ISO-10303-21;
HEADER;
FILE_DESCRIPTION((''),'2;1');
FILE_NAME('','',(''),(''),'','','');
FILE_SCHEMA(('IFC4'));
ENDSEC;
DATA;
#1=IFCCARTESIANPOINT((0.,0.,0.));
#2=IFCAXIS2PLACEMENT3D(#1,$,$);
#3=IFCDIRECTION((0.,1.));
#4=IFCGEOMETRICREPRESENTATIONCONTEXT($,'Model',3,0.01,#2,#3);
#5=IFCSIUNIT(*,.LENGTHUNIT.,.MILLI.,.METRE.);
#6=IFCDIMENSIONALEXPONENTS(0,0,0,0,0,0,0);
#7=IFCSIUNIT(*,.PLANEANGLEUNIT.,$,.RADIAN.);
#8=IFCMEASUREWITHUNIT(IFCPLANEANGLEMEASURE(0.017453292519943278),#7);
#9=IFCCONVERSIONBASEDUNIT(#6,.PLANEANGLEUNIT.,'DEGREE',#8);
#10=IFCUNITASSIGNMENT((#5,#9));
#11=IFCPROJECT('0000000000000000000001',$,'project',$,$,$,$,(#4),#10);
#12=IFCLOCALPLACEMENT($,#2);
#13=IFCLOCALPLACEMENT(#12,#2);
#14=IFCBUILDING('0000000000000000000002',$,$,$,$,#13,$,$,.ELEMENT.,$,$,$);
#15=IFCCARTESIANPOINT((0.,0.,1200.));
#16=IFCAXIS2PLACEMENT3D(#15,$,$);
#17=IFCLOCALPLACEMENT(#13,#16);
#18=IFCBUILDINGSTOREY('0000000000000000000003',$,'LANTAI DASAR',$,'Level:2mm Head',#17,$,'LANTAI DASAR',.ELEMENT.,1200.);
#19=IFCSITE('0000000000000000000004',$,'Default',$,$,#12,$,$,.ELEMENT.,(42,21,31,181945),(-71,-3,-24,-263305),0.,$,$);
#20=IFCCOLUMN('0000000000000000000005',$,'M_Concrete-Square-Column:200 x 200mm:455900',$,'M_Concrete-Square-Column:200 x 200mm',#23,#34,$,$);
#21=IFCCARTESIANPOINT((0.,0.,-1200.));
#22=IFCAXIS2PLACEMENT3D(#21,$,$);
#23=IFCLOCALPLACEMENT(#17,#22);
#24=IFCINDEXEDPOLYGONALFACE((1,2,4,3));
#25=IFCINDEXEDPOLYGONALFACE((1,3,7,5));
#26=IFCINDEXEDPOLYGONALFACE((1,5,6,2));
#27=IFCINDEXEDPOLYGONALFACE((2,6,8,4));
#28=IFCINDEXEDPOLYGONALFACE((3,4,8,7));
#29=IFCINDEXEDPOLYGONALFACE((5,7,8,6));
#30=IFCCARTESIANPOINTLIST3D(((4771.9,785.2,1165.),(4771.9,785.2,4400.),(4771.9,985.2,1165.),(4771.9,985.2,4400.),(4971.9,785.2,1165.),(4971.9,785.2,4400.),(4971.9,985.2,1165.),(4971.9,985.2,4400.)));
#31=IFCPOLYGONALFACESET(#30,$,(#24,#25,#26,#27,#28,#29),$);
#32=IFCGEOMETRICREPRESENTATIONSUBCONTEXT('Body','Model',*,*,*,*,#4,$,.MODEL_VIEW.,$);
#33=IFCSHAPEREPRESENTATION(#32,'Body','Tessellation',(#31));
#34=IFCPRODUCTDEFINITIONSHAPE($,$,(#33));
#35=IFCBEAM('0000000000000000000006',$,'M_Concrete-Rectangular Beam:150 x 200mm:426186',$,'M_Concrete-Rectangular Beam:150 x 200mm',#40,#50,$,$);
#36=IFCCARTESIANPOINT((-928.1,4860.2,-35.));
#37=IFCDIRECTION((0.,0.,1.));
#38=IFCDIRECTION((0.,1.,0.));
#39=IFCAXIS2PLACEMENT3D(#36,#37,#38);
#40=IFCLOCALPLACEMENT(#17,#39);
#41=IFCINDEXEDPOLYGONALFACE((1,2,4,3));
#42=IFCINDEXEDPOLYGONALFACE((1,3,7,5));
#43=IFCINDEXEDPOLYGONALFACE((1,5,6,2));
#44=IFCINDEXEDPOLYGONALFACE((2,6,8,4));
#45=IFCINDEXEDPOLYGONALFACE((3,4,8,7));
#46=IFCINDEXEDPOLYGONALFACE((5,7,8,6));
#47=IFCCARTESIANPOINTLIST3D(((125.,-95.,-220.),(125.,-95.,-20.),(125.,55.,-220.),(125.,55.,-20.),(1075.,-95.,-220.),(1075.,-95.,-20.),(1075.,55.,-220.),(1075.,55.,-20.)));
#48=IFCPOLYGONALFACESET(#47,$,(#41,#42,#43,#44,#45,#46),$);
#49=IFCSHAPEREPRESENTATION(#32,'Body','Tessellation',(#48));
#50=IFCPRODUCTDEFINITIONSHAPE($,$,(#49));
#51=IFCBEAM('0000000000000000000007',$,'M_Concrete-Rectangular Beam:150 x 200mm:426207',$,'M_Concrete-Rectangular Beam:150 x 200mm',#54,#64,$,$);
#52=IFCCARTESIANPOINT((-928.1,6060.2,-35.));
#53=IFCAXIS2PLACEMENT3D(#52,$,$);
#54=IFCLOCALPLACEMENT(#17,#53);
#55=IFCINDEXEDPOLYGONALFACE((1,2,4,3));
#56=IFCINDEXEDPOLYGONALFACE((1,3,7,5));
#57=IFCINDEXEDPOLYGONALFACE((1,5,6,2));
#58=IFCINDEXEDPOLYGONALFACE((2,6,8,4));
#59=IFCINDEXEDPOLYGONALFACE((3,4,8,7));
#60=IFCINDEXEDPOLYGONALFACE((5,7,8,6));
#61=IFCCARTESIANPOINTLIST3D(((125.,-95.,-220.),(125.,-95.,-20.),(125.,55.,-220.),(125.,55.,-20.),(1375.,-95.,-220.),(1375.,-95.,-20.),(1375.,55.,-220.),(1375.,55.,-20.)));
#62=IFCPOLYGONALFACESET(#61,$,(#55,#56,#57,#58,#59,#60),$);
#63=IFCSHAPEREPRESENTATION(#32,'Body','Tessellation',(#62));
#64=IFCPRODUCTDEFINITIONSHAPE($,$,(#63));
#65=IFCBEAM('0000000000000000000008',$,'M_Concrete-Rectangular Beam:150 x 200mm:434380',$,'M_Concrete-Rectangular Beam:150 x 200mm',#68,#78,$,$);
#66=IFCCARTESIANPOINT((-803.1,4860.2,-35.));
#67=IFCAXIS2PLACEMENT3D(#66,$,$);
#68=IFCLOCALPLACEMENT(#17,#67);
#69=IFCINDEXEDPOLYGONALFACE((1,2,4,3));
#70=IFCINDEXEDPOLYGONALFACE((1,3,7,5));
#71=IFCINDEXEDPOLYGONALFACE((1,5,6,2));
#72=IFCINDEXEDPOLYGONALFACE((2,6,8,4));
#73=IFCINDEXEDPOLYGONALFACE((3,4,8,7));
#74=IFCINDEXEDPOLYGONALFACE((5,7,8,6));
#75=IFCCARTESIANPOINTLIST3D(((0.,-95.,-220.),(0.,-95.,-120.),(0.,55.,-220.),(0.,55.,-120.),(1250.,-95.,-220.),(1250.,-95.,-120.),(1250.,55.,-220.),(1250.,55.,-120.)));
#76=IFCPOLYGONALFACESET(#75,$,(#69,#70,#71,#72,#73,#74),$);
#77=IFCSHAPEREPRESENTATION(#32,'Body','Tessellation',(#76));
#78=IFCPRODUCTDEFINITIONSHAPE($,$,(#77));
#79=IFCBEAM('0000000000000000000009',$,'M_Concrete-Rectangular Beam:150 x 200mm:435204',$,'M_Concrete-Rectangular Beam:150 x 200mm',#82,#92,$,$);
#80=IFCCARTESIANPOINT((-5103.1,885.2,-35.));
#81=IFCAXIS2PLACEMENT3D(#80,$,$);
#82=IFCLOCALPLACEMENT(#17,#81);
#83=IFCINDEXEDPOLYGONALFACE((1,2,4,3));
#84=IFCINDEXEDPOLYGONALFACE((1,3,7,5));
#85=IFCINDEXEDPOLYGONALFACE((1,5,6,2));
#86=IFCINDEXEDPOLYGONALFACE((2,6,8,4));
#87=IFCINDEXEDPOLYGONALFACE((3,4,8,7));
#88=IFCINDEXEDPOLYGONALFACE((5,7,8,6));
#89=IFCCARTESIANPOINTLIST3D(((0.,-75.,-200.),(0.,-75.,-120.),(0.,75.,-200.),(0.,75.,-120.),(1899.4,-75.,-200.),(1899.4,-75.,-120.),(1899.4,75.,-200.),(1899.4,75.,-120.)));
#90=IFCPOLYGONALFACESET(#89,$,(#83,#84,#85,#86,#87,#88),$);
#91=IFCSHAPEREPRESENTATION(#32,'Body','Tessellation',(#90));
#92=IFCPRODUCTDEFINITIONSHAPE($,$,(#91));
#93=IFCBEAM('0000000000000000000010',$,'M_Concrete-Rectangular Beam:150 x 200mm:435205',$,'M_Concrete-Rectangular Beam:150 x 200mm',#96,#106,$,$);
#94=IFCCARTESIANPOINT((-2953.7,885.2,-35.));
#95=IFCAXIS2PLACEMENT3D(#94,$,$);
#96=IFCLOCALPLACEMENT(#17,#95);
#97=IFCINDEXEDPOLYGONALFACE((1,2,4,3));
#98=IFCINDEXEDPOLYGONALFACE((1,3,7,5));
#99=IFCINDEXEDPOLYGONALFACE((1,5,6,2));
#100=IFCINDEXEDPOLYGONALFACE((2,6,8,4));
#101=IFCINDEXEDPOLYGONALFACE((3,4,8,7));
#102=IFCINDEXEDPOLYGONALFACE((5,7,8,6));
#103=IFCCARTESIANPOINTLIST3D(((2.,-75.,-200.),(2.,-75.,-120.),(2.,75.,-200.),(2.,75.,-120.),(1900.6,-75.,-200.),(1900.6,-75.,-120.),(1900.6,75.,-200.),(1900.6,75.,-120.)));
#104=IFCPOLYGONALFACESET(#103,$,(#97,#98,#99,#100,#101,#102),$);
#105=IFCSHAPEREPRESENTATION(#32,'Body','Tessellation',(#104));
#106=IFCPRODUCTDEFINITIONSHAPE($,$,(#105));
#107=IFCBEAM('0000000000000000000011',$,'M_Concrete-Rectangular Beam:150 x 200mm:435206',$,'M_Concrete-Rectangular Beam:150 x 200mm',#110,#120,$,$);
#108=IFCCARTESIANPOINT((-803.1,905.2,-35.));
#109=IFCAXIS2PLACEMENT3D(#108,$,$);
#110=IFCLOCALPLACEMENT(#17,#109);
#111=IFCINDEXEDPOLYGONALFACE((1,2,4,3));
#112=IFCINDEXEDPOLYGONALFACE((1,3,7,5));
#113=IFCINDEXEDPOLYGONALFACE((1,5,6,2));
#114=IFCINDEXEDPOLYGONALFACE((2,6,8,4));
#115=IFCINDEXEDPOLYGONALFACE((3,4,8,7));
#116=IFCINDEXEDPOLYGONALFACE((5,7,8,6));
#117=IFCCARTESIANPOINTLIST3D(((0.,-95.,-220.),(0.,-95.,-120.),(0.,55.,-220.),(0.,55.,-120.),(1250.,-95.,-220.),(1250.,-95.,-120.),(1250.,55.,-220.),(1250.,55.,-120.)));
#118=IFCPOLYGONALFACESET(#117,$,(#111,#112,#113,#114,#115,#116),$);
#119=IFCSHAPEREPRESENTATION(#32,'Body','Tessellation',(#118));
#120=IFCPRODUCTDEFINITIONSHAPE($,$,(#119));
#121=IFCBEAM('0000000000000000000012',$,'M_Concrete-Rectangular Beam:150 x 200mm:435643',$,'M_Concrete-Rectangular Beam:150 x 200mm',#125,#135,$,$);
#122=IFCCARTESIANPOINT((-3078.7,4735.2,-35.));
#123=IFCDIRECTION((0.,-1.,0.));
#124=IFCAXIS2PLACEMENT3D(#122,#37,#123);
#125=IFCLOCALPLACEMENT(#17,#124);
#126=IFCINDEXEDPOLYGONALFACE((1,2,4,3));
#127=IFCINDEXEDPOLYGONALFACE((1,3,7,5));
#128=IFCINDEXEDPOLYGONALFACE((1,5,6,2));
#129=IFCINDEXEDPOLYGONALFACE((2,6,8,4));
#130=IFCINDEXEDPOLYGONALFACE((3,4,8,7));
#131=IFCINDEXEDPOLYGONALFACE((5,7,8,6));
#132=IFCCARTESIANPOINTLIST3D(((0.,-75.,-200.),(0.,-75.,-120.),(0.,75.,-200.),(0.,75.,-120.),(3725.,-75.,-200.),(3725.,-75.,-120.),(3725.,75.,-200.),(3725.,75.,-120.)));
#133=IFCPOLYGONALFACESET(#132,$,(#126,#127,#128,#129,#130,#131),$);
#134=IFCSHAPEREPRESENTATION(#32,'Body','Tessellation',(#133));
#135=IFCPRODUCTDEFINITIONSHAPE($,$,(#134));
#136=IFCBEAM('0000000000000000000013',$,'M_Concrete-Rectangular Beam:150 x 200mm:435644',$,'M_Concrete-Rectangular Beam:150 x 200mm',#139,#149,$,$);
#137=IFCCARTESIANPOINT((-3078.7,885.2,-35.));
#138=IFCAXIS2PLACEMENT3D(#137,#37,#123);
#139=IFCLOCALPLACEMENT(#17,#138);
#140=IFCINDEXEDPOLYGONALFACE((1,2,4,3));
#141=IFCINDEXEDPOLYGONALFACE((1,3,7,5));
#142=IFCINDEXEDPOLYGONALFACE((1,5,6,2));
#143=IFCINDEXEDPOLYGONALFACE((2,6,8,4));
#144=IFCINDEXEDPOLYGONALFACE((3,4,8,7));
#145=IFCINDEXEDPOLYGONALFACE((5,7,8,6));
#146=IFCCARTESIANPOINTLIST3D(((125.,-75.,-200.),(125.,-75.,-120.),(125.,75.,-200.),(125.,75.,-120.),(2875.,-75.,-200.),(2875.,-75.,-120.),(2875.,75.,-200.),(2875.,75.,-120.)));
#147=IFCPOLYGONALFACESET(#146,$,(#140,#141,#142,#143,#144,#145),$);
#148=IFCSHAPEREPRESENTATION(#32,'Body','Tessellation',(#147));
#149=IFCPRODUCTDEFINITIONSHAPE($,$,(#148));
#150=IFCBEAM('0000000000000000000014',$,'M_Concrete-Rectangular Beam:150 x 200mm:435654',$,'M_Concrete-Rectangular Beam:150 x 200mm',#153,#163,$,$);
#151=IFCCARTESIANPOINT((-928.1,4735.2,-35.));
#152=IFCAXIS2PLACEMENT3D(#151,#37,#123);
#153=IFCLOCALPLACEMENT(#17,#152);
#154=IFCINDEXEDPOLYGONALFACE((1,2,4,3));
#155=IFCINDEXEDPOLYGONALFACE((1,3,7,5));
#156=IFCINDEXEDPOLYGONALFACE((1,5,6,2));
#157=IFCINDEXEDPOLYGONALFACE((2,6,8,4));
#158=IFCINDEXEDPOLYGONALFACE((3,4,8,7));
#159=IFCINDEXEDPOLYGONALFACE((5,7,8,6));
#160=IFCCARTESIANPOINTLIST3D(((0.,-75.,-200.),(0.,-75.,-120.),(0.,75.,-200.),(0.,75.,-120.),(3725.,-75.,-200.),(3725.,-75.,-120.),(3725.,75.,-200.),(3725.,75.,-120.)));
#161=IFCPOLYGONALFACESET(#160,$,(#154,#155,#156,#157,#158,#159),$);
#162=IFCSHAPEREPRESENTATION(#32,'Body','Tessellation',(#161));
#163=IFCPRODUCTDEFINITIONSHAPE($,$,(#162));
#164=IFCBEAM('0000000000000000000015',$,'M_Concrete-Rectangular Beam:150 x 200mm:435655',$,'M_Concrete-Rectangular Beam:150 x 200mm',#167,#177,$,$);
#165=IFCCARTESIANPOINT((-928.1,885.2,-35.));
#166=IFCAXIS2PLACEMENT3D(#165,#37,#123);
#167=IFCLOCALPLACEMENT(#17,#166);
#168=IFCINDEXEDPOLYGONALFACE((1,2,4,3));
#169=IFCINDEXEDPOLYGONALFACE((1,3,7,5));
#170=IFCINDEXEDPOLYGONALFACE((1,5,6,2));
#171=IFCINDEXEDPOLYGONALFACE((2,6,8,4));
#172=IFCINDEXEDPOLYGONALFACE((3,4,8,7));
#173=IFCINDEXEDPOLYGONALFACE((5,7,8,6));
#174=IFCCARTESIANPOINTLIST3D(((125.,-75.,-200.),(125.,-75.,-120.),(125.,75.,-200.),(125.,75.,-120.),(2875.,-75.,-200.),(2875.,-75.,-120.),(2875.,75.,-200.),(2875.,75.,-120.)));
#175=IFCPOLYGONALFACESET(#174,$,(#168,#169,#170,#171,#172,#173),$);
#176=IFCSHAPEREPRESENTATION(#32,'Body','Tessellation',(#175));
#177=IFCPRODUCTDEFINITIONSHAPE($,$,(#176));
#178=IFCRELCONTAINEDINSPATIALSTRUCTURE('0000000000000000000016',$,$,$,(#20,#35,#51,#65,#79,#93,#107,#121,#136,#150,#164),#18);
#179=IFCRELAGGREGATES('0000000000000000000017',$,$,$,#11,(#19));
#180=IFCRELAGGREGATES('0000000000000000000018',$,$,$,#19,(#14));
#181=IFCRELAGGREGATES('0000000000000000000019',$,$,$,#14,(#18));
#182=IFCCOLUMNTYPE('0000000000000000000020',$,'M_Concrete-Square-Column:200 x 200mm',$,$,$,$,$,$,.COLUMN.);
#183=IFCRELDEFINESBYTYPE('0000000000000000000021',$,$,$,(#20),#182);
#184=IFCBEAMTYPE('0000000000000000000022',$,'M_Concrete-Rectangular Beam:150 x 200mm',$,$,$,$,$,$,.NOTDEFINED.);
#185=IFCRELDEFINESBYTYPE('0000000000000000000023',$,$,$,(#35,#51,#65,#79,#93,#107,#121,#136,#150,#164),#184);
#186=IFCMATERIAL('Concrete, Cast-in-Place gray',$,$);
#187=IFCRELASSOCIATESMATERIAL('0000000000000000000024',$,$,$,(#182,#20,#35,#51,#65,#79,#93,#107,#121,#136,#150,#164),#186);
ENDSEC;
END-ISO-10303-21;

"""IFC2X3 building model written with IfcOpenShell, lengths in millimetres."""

from ifc_helpers import new_model, entity, si_unit, converted_unit, direction, frame, frame_2d, origin, origin_2d_with_axis, place, context, subcontext, project, spatial, rectangle, extrude, source, transform, mapped, material, type_object, type_shapes, element, save


model = new_model("IFC2X3")

# Units and contexts
model_context = context("Model", 3, precision=0.01, world=origin(), true_north=direction((0.0, 1.0)))
body_context = subcontext(model_context, "Body", "Model", "MODEL_VIEW")
ifc_project = project(units=[si_unit("LENGTHUNIT", "METRE", prefix="MILLI"), converted_unit("PLANEANGLEUNIT", "DEGREE", entity("IfcPlaneAngleMeasure", 0.017453292519943278), si_unit("PLANEANGLEUNIT", "RADIAN"), dimensions=[0, 0, 0, 0, 0, 0, 0])], contexts=[model_context])

# Site, building, storey
site_placement = place(None, origin())
site = spatial("IfcSite", under=ifc_project, at=site_placement, Name="Default", CompositionType="ELEMENT", RefLatitude=(42, 21, 31, 181945), RefLongitude=(-71, -3, -24, -263305), RefElevation=0.0)
building_placement = place(site_placement, origin())
building = spatial("IfcBuilding", under=site, at=building_placement, CompositionType="ELEMENT")
storey_placement = place(building_placement, frame((0.0, 0.0, 1200.0)))
storey = spatial("IfcBuildingStorey", under=building, at=storey_placement, Name="LANTAI DASAR", ObjectType="Level:2mm Head", LongName="LANTAI DASAR", CompositionType="ELEMENT", Elevation=1200.0)

# Column
ifc_material_1 = material(Name="Concrete, Cast-in-Place gray")
column_type = type_object("IfcColumnType", Name="M_Concrete-Square-Column:200 x 200mm", PredefinedType="COLUMN", material=ifc_material_1)
shared_shape = source(origin(), body_context, "Body", "SweptSolid", [
    extrude(rectangle(XDim=200.0, YDim=200.0, at=origin_2d_with_axis()), frame((4871.9, 885.2, 1165.0), z_axis=(0.0, 0.0, 1.0), x_axis=(-1.0, 0.0, 0.0)), (0.0, 0.0, 1.0), 3235.0),
])
type_shapes(column_type, [shared_shape])
column_placement = place(storey_placement, frame((0.0, 0.0, -1200.0)))
element("IfcColumn", 1, at=column_placement, inside=storey, type_object=column_type, material=ifc_material_1, Name="M_Concrete-Square-Column:200 x 200mm:455900", ObjectType="M_Concrete-Square-Column:200 x 200mm", context=body_context, shape_type="MappedRepresentation", body=[
    mapped(shared_shape, transform((0.0, 0.0, 0.0), scale=1.0)),
])

# Beams
beam_type = type_object("IfcBeamType", Name="M_Concrete-Rectangular Beam:150 x 200mm", PredefinedType="NOTDEFINED")
beam_1_placement = place(storey_placement, frame((-928.1, 4860.2, -35.0), z_axis=(0.0, 0.0, 1.0), x_axis=(0.0, 1.0, 0.0)))
element("IfcBeam", 2, at=beam_1_placement, inside=storey, type_object=beam_type, material=ifc_material_1, Name="M_Concrete-Rectangular Beam:150 x 200mm:426186", ObjectType="M_Concrete-Rectangular Beam:150 x 200mm", context=body_context, shape_type="SweptSolid", body=[
    extrude(rectangle(XDim=200.0, YDim=150.0, at=frame_2d((0.0, 0.0), x_axis=(1.0, 0.0))), frame((125.0, -20.0, -120.0), z_axis=(1.0, 0.0, 0.0), x_axis=(0.0, 0.0, -1.0)), (0.0, 0.0, 1.0), 950.0),
])
beam_2_placement = place(storey_placement, frame((-928.1, 6060.2, -35.0)))
element("IfcBeam", 3, at=beam_2_placement, inside=storey, type_object=beam_type, material=ifc_material_1, Name="M_Concrete-Rectangular Beam:150 x 200mm:426207", ObjectType="M_Concrete-Rectangular Beam:150 x 200mm", context=body_context, shape_type="SweptSolid", body=[
    extrude(rectangle(XDim=200.0, YDim=150.0, at=frame_2d((0.0, 0.0), x_axis=(1.0, 0.0))), frame((125.0, -20.0, -120.0), z_axis=(1.0, 0.0, 0.0), x_axis=(0.0, 0.0, -1.0)), (0.0, 0.0, 1.0), 1250.0),
])
beam_3_placement = place(storey_placement, frame((-803.1, 4860.2, -35.0)))
element("IfcBeam", 4, at=beam_3_placement, inside=storey, type_object=beam_type, material=ifc_material_1, Name="M_Concrete-Rectangular Beam:150 x 200mm:434380", ObjectType="M_Concrete-Rectangular Beam:150 x 200mm", context=body_context, shape_type="SweptSolid", body=[
    extrude(rectangle(XDim=100.0, YDim=150.0, at=frame_2d((0.0, 0.0), x_axis=(1.0, 0.0))), frame((0.0, -20.0, -170.0), z_axis=(1.0, 0.0, 0.0), x_axis=(0.0, 0.0, -1.0)), (0.0, 0.0, 1.0), 1250.0),
])
beam_4_placement = place(storey_placement, frame((-5103.1, 885.2, -35.0)))
element("IfcBeam", 5, at=beam_4_placement, inside=storey, type_object=beam_type, material=ifc_material_1, Name="M_Concrete-Rectangular Beam:150 x 200mm:435204", ObjectType="M_Concrete-Rectangular Beam:150 x 200mm", context=body_context, shape_type="SweptSolid", body=[
    extrude(rectangle(XDim=80.0, YDim=150.0, at=frame_2d((0.0, 0.0), x_axis=(1.0, 0.0))), frame((0.0, 0.0, -160.0), z_axis=(1.0, 0.0, 0.0), x_axis=(0.0, 0.0, -1.0)), (0.0, 0.0, 1.0), 1899.4),
])
beam_5_placement = place(storey_placement, frame((-2953.7, 885.2, -35.0)))
element("IfcBeam", 6, at=beam_5_placement, inside=storey, type_object=beam_type, material=ifc_material_1, Name="M_Concrete-Rectangular Beam:150 x 200mm:435205", ObjectType="M_Concrete-Rectangular Beam:150 x 200mm", context=body_context, shape_type="SweptSolid", body=[
    extrude(rectangle(XDim=80.0, YDim=150.0, at=frame_2d((0.0, 0.0), x_axis=(1.0, 0.0))), frame((2.0, 0.0, -160.0), z_axis=(1.0, 0.0, 0.0), x_axis=(0.0, 0.0, -1.0)), (0.0, 0.0, 1.0), 1898.6),
])
beam_6_placement = place(storey_placement, frame((-803.1, 905.2, -35.0)))
element("IfcBeam", 7, at=beam_6_placement, inside=storey, type_object=beam_type, material=ifc_material_1, Name="M_Concrete-Rectangular Beam:150 x 200mm:435206", ObjectType="M_Concrete-Rectangular Beam:150 x 200mm", context=body_context, shape_type="SweptSolid", body=[
    extrude(rectangle(XDim=100.0, YDim=150.0, at=frame_2d((0.0, 0.0), x_axis=(1.0, 0.0))), frame((0.0, -20.0, -170.0), z_axis=(1.0, 0.0, 0.0), x_axis=(0.0, 0.0, -1.0)), (0.0, 0.0, 1.0), 1250.0),
])
beam_7_placement = place(storey_placement, frame((-3078.7, 4735.2, -35.0), z_axis=(0.0, 0.0, 1.0), x_axis=(0.0, -1.0, 0.0)))
element("IfcBeam", 8, at=beam_7_placement, inside=storey, type_object=beam_type, material=ifc_material_1, Name="M_Concrete-Rectangular Beam:150 x 200mm:435643", ObjectType="M_Concrete-Rectangular Beam:150 x 200mm", context=body_context, shape_type="SweptSolid", body=[
    extrude(rectangle(XDim=80.0, YDim=150.0, at=frame_2d((0.0, 0.0), x_axis=(1.0, 0.0))), frame((0.0, 0.0, -160.0), z_axis=(1.0, 0.0, 0.0), x_axis=(0.0, 0.0, -1.0)), (0.0, 0.0, 1.0), 3725.0),
])
beam_8_placement = place(storey_placement, frame((-3078.7, 885.2, -35.0), z_axis=(0.0, 0.0, 1.0), x_axis=(0.0, -1.0, 0.0)))
element("IfcBeam", 9, at=beam_8_placement, inside=storey, type_object=beam_type, material=ifc_material_1, Name="M_Concrete-Rectangular Beam:150 x 200mm:435644", ObjectType="M_Concrete-Rectangular Beam:150 x 200mm", context=body_context, shape_type="SweptSolid", body=[
    extrude(rectangle(XDim=80.0, YDim=150.0, at=frame_2d((0.0, 0.0), x_axis=(1.0, 0.0))), frame((125.0, 0.0, -160.0), z_axis=(1.0, 0.0, 0.0), x_axis=(0.0, 0.0, -1.0)), (0.0, 0.0, 1.0), 2750.0),
])
beam_9_placement = place(storey_placement, frame((-928.1, 4735.2, -35.0), z_axis=(0.0, 0.0, 1.0), x_axis=(0.0, -1.0, 0.0)))
element("IfcBeam", 10, at=beam_9_placement, inside=storey, type_object=beam_type, material=ifc_material_1, Name="M_Concrete-Rectangular Beam:150 x 200mm:435654", ObjectType="M_Concrete-Rectangular Beam:150 x 200mm", context=body_context, shape_type="SweptSolid", body=[
    extrude(rectangle(XDim=80.0, YDim=150.0, at=frame_2d((0.0, 0.0), x_axis=(1.0, 0.0))), frame((0.0, 0.0, -160.0), z_axis=(1.0, 0.0, 0.0), x_axis=(0.0, 0.0, -1.0)), (0.0, 0.0, 1.0), 3725.0),
])
beam_10_placement = place(storey_placement, frame((-928.1, 885.2, -35.0), z_axis=(0.0, 0.0, 1.0), x_axis=(0.0, -1.0, 0.0)))
element("IfcBeam", 11, at=beam_10_placement, inside=storey, type_object=beam_type, material=ifc_material_1, Name="M_Concrete-Rectangular Beam:150 x 200mm:435655", ObjectType="M_Concrete-Rectangular Beam:150 x 200mm", context=body_context, shape_type="SweptSolid", body=[
    extrude(rectangle(XDim=80.0, YDim=150.0, at=frame_2d((0.0, 0.0), x_axis=(1.0, 0.0))), frame((125.0, 0.0, -160.0), z_axis=(1.0, 0.0, 0.0), x_axis=(0.0, 0.0, -1.0)), (0.0, 0.0, 1.0), 2750.0),
])

save(model, "model.ifc")
